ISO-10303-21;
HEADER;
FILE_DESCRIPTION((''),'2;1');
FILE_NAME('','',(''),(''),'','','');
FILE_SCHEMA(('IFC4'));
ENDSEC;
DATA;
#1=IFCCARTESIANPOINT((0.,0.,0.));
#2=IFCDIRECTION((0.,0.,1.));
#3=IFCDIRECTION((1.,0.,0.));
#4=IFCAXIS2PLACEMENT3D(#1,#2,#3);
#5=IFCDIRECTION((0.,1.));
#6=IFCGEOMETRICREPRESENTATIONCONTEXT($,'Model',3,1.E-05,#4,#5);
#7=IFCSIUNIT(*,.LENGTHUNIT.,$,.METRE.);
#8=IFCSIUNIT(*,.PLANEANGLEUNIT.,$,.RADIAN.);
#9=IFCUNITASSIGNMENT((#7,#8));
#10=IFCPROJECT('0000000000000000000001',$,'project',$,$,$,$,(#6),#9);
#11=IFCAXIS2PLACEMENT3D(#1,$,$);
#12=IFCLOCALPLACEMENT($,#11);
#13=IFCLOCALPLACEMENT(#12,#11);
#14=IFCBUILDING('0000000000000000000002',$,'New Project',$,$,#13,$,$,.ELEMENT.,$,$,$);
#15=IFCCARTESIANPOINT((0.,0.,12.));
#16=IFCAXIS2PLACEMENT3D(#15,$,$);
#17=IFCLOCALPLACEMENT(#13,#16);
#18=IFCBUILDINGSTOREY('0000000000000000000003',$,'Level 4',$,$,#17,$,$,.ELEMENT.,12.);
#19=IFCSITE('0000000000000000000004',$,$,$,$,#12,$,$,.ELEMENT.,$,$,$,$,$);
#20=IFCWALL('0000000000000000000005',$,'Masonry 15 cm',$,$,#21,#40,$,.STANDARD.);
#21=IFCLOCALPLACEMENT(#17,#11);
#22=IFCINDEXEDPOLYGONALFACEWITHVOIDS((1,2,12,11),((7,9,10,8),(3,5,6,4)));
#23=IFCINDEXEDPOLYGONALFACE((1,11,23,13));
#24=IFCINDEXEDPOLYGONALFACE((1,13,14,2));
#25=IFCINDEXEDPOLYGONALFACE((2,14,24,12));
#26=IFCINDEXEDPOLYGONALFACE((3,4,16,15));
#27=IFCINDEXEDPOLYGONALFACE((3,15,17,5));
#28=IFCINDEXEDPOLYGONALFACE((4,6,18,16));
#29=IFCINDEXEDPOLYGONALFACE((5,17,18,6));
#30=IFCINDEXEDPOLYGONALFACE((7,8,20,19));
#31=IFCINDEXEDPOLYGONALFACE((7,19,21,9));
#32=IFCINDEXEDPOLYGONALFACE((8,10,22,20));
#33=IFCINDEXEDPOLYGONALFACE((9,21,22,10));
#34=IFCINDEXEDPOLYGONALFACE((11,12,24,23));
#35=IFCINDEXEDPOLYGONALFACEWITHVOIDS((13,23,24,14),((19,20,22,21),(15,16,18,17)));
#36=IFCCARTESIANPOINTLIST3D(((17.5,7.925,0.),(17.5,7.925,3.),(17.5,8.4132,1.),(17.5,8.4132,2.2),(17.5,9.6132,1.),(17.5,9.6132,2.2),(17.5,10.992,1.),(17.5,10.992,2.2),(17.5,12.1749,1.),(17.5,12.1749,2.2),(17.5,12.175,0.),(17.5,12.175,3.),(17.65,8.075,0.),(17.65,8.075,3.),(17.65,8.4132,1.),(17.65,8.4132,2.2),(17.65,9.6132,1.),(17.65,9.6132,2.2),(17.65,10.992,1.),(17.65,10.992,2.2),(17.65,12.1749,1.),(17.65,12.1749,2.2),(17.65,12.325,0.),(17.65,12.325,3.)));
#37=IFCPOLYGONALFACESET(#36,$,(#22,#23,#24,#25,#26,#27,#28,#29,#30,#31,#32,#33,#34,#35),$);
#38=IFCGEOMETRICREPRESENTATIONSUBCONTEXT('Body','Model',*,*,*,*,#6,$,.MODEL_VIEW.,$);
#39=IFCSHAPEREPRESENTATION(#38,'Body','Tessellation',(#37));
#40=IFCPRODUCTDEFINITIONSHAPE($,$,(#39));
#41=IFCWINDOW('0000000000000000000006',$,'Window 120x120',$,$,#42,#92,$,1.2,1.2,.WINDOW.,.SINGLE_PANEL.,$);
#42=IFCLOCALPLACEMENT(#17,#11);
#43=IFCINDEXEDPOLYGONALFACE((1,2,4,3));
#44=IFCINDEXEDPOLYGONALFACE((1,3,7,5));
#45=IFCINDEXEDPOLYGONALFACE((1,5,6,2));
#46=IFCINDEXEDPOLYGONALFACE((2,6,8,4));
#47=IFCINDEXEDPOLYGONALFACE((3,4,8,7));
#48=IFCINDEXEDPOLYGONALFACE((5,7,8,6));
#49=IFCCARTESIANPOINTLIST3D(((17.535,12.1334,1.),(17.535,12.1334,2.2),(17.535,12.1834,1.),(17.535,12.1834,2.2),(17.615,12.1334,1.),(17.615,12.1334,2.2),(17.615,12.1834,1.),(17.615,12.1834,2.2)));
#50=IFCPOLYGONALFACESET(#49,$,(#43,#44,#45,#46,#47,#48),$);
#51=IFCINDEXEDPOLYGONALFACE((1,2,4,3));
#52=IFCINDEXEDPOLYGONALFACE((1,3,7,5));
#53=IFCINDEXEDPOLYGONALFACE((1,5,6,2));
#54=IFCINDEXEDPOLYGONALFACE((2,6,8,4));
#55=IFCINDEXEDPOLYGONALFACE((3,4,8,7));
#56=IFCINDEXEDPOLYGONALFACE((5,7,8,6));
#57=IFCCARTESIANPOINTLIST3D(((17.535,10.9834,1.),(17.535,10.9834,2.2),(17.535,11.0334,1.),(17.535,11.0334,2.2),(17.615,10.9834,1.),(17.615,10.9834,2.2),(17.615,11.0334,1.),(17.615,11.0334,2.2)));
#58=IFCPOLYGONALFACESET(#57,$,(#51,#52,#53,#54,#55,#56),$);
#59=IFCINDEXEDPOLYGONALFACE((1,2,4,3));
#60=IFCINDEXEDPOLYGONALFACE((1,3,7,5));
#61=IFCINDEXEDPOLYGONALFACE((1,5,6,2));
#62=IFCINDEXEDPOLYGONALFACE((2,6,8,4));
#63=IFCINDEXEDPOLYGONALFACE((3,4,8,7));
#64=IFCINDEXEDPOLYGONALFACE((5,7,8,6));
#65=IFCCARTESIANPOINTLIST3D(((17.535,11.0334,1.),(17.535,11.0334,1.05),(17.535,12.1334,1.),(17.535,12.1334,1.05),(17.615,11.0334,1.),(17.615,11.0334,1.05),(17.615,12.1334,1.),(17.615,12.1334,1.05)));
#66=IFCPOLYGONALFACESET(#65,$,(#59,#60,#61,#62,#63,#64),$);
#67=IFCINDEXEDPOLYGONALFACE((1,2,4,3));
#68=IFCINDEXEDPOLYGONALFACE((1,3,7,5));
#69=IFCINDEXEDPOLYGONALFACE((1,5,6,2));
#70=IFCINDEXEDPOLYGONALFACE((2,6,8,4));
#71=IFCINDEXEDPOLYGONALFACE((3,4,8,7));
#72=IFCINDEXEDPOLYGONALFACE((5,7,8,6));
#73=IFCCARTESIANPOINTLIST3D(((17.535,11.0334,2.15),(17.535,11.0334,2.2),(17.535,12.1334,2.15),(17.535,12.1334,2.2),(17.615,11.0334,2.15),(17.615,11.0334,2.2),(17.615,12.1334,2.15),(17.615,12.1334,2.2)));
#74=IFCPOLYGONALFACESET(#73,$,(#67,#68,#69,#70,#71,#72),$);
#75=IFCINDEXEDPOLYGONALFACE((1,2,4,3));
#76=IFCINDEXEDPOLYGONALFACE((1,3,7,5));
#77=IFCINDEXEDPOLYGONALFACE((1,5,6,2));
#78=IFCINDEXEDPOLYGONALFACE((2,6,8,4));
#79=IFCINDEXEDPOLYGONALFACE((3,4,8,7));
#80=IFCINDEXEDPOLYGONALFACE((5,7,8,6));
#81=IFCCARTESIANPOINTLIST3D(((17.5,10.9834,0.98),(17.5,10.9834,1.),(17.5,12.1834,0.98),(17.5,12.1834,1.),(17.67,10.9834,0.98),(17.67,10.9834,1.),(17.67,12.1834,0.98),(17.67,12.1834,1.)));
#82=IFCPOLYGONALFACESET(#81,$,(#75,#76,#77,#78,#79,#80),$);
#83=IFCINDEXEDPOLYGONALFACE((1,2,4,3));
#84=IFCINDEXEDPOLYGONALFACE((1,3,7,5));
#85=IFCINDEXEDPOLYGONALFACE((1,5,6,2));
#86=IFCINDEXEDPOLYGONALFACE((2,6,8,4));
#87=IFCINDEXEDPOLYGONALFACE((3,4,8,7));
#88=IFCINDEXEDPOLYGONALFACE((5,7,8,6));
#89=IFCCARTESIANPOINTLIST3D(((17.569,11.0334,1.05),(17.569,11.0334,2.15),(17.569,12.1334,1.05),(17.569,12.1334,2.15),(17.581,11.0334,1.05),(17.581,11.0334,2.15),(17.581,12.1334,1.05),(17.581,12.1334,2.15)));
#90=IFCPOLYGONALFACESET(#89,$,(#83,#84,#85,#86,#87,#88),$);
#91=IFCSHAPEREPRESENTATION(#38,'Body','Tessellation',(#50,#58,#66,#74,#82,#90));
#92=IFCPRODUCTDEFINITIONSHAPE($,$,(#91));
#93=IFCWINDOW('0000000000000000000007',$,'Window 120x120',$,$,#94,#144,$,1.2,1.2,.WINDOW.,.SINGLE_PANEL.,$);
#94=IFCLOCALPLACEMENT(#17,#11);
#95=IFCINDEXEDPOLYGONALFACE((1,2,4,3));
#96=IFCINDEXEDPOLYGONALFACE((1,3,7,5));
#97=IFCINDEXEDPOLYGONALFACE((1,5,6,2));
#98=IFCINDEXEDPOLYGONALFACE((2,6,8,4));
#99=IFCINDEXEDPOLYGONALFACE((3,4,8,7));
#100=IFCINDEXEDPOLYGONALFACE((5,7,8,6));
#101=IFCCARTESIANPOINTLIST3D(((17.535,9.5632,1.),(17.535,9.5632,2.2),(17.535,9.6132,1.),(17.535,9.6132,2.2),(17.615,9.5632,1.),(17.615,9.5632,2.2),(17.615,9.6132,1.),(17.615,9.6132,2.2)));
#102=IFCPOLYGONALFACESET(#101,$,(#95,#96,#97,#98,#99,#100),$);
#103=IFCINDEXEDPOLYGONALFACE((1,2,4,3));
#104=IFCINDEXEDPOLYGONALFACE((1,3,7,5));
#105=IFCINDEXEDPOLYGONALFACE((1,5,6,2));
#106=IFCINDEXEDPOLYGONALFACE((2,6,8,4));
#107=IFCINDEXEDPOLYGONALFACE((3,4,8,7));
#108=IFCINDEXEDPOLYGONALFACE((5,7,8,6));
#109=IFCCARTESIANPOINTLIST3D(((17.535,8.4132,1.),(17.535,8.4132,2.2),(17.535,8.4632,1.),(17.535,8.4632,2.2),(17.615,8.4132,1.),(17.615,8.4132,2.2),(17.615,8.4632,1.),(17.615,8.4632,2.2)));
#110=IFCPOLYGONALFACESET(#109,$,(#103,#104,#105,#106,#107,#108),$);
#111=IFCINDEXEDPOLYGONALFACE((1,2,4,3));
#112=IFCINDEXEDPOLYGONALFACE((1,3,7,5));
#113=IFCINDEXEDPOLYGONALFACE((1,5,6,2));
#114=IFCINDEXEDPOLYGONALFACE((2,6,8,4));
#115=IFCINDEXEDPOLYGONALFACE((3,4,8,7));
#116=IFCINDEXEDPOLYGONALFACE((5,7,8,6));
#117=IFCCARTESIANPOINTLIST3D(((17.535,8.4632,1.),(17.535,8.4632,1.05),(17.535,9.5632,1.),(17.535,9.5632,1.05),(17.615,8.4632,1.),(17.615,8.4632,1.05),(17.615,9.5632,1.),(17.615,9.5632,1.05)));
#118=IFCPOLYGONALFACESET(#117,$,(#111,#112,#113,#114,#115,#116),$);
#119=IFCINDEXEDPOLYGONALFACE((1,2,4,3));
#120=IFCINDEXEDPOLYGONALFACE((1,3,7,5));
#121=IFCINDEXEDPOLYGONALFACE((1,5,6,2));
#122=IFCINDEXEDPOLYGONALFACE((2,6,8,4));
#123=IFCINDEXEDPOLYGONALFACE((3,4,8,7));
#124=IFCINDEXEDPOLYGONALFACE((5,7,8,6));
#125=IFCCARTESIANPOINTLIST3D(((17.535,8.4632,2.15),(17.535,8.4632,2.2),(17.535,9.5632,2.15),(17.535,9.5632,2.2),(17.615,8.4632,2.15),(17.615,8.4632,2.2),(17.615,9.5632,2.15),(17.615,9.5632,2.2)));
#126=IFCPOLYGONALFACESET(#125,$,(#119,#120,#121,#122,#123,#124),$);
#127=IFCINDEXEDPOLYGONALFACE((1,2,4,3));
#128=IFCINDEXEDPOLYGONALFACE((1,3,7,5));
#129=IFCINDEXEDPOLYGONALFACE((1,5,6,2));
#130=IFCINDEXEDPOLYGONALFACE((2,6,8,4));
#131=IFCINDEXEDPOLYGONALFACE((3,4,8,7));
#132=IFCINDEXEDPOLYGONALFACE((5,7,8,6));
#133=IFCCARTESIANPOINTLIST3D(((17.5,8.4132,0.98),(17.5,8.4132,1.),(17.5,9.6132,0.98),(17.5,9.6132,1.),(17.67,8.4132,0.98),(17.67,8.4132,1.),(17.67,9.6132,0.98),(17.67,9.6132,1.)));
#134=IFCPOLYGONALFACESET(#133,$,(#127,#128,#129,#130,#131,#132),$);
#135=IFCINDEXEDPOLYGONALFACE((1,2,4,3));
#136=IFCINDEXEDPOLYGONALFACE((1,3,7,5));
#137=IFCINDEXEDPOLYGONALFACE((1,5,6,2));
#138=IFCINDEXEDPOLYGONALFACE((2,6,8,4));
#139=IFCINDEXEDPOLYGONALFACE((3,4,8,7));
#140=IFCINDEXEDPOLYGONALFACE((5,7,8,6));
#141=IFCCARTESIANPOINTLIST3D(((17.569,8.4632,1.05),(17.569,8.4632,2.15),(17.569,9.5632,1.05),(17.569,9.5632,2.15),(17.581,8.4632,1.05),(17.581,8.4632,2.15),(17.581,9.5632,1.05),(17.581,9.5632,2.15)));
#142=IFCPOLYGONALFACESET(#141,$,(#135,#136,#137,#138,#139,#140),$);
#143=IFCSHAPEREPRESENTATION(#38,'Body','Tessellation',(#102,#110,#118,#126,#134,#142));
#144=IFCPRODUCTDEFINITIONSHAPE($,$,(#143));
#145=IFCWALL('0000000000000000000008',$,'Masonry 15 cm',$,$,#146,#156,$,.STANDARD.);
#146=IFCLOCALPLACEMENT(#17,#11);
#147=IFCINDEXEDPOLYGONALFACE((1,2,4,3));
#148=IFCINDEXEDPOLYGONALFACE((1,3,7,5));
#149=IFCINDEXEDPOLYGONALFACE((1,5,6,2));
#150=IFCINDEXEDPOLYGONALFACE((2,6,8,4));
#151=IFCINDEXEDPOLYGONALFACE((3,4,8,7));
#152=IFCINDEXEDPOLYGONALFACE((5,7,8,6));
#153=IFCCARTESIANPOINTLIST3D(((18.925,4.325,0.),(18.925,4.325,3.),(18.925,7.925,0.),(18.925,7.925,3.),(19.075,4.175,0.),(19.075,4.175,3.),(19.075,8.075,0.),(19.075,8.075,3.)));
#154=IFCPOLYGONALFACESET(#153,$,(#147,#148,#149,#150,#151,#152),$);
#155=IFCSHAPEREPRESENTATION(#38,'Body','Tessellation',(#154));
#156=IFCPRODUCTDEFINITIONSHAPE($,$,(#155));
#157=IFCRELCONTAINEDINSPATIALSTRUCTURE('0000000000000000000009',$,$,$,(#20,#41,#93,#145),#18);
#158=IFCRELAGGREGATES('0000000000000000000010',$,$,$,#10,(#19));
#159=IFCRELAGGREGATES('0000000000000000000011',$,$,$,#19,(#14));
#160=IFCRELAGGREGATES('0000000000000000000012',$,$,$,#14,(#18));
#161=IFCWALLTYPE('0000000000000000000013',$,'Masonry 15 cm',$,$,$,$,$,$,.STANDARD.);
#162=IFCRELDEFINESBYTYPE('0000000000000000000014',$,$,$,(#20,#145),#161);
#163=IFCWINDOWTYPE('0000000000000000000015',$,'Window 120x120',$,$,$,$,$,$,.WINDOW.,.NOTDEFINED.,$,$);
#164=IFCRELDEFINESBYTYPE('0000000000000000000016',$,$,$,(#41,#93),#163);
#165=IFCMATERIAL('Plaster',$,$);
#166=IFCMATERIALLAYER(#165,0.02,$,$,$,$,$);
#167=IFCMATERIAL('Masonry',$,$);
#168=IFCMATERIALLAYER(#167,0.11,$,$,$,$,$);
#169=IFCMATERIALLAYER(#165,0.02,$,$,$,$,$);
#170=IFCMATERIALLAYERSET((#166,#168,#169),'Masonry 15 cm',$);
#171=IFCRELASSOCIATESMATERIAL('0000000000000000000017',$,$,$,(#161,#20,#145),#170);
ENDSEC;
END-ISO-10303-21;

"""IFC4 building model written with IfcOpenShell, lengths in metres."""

from ifc_helpers import new_model, si_unit, direction, frame, frame_2d, origin, origin_with_axes, place, context, subcontext, project, spatial, polyline, rectangle, outline, extrude, material, layer, layer_set, layer_usage, type_object, element, fill, save


model = new_model("IFC4")

# Units and contexts
model_context = context("Model", 3, precision=1e-05, world=origin_with_axes(), true_north=direction((0.0, 1.0)))
body_context = subcontext(model_context, "Body", "Model", "MODEL_VIEW")
ifc_project = project(units=[si_unit("LENGTHUNIT", "METRE"), si_unit("PLANEANGLEUNIT", "RADIAN")], contexts=[model_context])

# Site, building, storey
site_placement = place(None, origin())
site = spatial("IfcSite", under=ifc_project, at=site_placement, CompositionType="ELEMENT")
building_placement = place(site_placement, origin())
building = spatial("IfcBuilding", under=site, at=building_placement, Name="New Project", CompositionType="ELEMENT")
storey_placement = place(building_placement, frame((0.0, 0.0, 12.0)))
storey = spatial("IfcBuildingStorey", under=building, at=storey_placement, Name="Level 4", CompositionType="ELEMENT", Elevation=12.0)

# Shared definitions
ifc_material_1 = material(Name="Plaster")
ifc_layer_1 = layer(ifc_material_1, 0.02)
ifc_material_2 = material(Name="Masonry")
ifc_layer_2 = layer(ifc_material_2, 0.11)
ifc_layer_3 = layer(ifc_material_1, 0.02)
ifc_layer_set_1 = layer_set([ifc_layer_1, ifc_layer_2, ifc_layer_3], Name="Masonry 15 cm")
ifc_layer_usage_1 = layer_usage(ifc_layer_set_1, "AXIS2", "NEGATIVE", 0.075)
wall_type_1 = type_object("IfcWallType", Name="Masonry 15 cm", PredefinedType="STANDARD", material=ifc_layer_set_1)
window_type = type_object("IfcWindowType", Name="Window 120x120", PartitioningType="NOTDEFINED", PredefinedType="WINDOW")

# Wall, openings, windows
wall_1_placement = place(storey_placement, frame((17.575, 12.25, 0.0), z_axis=(0.0, 0.0, 1.0), x_axis=(0.0, -1.0, 0.0)))
wall_1 = element("IfcWall", 1, at=wall_1_placement, inside=storey, type_object=wall_type_1, material=ifc_layer_usage_1, Name="Masonry 15 cm", PredefinedType="STANDARD", context=body_context, shape_type="SweptSolid", body=[
    extrude(outline(polyline([(0.075, -0.075), (4.325, -0.075), (4.175, 0.075), (-0.075, 0.075), (0.075, -0.075)])), origin(), (0.0, 0.0, 1.0), 3.0),
])
opening_1_placement = place(wall_1_placement, frame((0.0751, 0.0, 1.0)))
opening_1 = element("IfcOpeningElement", 2, at=opening_1_placement, cuts=wall_1, PredefinedType="OPENING", context=body_context, shape_type="SweptSolid", body=[
    extrude(rectangle(XDim=1.1829, YDim=0.25, at=frame_2d((0.5915, 0.0))), origin(), (0.0, 0.0, 1.0), 1.2),
])
opening_2_placement = place(wall_1_placement, frame((2.6368, 0.0, 1.0)))
opening_2 = element("IfcOpeningElement", 3, at=opening_2_placement, cuts=wall_1, PredefinedType="OPENING", context=body_context, shape_type="SweptSolid", body=[
    extrude(rectangle(XDim=1.2, YDim=0.25, at=frame_2d((0.6, 0.0))), origin(), (0.0, 0.0, 1.0), 1.2),
])
window_1_placement = place(opening_1_placement, origin())
window_1 = element("IfcWindow", 4, at=window_1_placement, inside=storey, type_object=window_type, Name="Window 120x120", OverallHeight=1.2, OverallWidth=1.2, PartitioningType="SINGLE_PANEL", PredefinedType="WINDOW", context=body_context, shape_type="SweptSolid", body=[
    extrude(outline(polyline([(-0.0085, -0.04), (0.0415, -0.04), (0.0415, 0.04), (-0.0085, 0.04), (-0.0085, -0.04)])), origin(), (0.0, 0.0, 1.0), 1.2),
    extrude(outline(polyline([(1.1415, -0.04), (1.1915, -0.04), (1.1915, 0.04), (1.1415, 0.04), (1.1415, -0.04)])), origin(), (0.0, 0.0, 1.0), 1.2),
    extrude(outline(polyline([(0.0415, -0.04), (1.1415, -0.04), (1.1415, 0.04), (0.0415, 0.04), (0.0415, -0.04)])), origin(), (0.0, 0.0, 1.0), 0.05),
    extrude(outline(polyline([(0.0415, -0.04), (1.1415, -0.04), (1.1415, 0.04), (0.0415, 0.04), (0.0415, -0.04)])), frame((0.0, 0.0, 1.15)), (0.0, 0.0, 1.0), 0.05),
    extrude(outline(polyline([(-0.0085, -0.075), (1.1915, -0.075), (1.1915, 0.095), (-0.0085, 0.095), (-0.0085, -0.075)])), frame((0.0, 0.0, -0.02)), (0.0, 0.0, 1.0), 0.02),
    extrude(outline(polyline([(0.0415, -0.006), (1.1415, -0.006), (1.1415, 0.006), (0.0415, 0.006), (0.0415, -0.006)])), frame((0.0, 0.0, 0.05)), (0.0, 0.0, 1.0), 1.1),
])
fill(opening_1, window_1)
window_2_placement = place(opening_2_placement, origin())
window_2 = element("IfcWindow", 5, at=window_2_placement, inside=storey, type_object=window_type, Name="Window 120x120", OverallHeight=1.2, OverallWidth=1.2, PartitioningType="SINGLE_PANEL", PredefinedType="WINDOW", context=body_context, shape_type="SweptSolid", body=[
    extrude(outline(polyline([(0.0, -0.04), (0.05, -0.04), (0.05, 0.04), (0.0, 0.04), (0.0, -0.04)])), origin(), (0.0, 0.0, 1.0), 1.2),
    extrude(outline(polyline([(1.15, -0.04), (1.2, -0.04), (1.2, 0.04), (1.15, 0.04), (1.15, -0.04)])), origin(), (0.0, 0.0, 1.0), 1.2),
    extrude(outline(polyline([(0.05, -0.04), (1.15, -0.04), (1.15, 0.04), (0.05, 0.04), (0.05, -0.04)])), origin(), (0.0, 0.0, 1.0), 0.05),
    extrude(outline(polyline([(0.05, -0.04), (1.15, -0.04), (1.15, 0.04), (0.05, 0.04), (0.05, -0.04)])), frame((0.0, 0.0, 1.15)), (0.0, 0.0, 1.0), 0.05),
    extrude(outline(polyline([(0.0, -0.075), (1.2, -0.075), (1.2, 0.095), (0.0, 0.095), (0.0, -0.075)])), frame((0.0, 0.0, -0.02)), (0.0, 0.0, 1.0), 0.02),
    extrude(outline(polyline([(0.05, -0.006), (1.15, -0.006), (1.15, 0.006), (0.05, 0.006), (0.05, -0.006)])), frame((0.0, 0.0, 0.05)), (0.0, 0.0, 1.0), 1.1),
])
fill(opening_2, window_2)

# Wall
wall_2_placement = place(storey_placement, frame((19.0, 8.0, 0.0), z_axis=(0.0, 0.0, 1.0), x_axis=(0.0, -1.0, 0.0)))
element("IfcWall", 6, at=wall_2_placement, inside=storey, type_object=wall_type_1, material=ifc_layer_usage_1, Name="Masonry 15 cm", PredefinedType="STANDARD", context=body_context, shape_type="SweptSolid", body=[
    extrude(outline(polyline([(0.075, -0.075), (3.675, -0.075), (3.825, 0.075), (-0.075, 0.075), (0.075, -0.075)])), origin(), (0.0, 0.0, 1.0), 3.0),
])

save(model, "model.ifc")
